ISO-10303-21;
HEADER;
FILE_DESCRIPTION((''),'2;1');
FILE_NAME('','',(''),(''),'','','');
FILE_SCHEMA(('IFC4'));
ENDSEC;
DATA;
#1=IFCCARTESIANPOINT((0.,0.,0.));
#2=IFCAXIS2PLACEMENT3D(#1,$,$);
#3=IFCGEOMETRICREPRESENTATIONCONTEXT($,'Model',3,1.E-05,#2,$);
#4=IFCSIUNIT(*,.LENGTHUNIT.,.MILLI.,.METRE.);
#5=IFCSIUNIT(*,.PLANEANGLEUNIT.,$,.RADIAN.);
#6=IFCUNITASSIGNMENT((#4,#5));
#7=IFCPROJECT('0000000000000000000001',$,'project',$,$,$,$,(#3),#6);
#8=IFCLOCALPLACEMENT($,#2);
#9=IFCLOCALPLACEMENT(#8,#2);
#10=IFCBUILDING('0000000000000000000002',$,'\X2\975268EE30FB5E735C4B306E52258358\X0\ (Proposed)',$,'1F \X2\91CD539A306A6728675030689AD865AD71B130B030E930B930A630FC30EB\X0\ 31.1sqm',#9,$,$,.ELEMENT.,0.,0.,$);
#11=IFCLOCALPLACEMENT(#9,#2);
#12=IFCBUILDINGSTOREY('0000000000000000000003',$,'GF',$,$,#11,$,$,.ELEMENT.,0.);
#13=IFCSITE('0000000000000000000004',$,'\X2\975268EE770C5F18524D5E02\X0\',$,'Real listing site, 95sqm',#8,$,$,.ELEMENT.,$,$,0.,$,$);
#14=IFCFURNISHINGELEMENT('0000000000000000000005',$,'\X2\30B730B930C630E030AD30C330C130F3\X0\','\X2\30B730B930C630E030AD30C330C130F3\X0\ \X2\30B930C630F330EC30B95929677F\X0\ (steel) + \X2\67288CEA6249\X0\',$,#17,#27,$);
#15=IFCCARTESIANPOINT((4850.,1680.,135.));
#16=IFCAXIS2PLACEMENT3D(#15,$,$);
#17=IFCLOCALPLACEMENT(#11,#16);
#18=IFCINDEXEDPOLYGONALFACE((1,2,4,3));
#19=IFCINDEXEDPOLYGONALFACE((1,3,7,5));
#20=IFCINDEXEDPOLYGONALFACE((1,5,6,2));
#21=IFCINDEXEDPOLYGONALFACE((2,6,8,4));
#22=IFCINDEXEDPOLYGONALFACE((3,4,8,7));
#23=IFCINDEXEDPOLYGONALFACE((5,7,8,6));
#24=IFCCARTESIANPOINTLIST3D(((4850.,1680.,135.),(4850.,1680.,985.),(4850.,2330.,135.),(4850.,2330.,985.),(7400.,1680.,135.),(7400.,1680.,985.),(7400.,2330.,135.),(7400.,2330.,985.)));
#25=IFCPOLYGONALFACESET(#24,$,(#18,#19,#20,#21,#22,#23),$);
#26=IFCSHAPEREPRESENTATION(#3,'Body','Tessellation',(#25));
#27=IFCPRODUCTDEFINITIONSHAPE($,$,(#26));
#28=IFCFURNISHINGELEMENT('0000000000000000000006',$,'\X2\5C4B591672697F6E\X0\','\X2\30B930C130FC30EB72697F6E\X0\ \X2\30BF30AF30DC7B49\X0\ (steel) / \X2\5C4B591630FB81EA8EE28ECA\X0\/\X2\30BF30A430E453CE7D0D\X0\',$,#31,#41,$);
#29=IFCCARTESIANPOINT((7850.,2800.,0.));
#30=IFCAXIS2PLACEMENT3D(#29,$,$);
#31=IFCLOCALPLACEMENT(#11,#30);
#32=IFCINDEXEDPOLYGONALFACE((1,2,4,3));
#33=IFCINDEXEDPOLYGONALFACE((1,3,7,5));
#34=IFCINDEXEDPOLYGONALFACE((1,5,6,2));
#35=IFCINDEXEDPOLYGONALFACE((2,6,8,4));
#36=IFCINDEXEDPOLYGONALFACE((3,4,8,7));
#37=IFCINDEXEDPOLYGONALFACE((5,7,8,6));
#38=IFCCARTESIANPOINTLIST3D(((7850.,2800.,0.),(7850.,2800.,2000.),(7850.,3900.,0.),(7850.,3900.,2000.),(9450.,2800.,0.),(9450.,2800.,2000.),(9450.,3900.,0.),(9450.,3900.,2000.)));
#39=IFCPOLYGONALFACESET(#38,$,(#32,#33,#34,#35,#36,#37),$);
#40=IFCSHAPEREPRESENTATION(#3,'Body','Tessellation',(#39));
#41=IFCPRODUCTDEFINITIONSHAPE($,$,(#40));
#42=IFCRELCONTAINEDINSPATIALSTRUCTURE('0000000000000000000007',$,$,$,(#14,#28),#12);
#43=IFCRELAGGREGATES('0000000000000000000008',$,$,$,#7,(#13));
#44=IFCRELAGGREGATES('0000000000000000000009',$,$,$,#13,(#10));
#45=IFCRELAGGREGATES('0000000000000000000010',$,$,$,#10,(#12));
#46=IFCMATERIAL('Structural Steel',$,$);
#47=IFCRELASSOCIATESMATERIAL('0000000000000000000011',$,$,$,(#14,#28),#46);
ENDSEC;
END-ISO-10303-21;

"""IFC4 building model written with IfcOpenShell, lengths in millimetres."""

from ifc_helpers import new_model, si_unit, frame, frame_2d, origin, place, context, project, spatial, rectangle, extrude, material, element, save


model = new_model("IFC4")

# Units and contexts
model_context = context("Model", 3, precision=1e-05, world=origin())
ifc_project = project(units=[si_unit("LENGTHUNIT", "METRE", prefix="MILLI"), si_unit("PLANEANGLEUNIT", "RADIAN")], contexts=[model_context])

# Site, building, storey
site_placement = place(None, origin())
site = spatial("IfcSite", under=ifc_project, at=site_placement, Name="青森県弘前市", ObjectType="Real listing site, 95sqm", CompositionType="ELEMENT", RefElevation=0.0)
building_placement = place(site_placement, origin())
building = spatial("IfcBuilding", under=site, at=building_placement, Name="青森・平屋の別荘 (Proposed)", ObjectType="1F 重厚な木材と高断熱グラスウール 31.1sqm", CompositionType="ELEMENT", ElevationOfRefHeight=0.0, ElevationOfTerrain=0.0)
storey_placement = place(building_placement, origin())
storey = spatial("IfcBuildingStorey", under=building, at=storey_placement, Name="GF", CompositionType="ELEMENT", Elevation=0.0)

# Shared definitions
ifc_material_1 = material(Name="Structural Steel")

# Furnishing elements
furnishing_1_placement = place(storey_placement, frame((4850.0, 1680.0, 135.0)))
element("IfcFurnishingElement", 1, at=furnishing_1_placement, inside=storey, material=ifc_material_1, Name="システムキッチン", Description="システムキッチン ステンレス天板 (steel) + 木質扉", context=model_context, shape_type="SweptSolid", body=[
    extrude(rectangle(XDim=2550.0, YDim=650.0, at=frame_2d((1275.0, 325.0))), frame((4850.0, 1680.0, 135.0)), (0.0, 0.0, 1.0), 850.0),
])
furnishing_2_placement = place(storey_placement, frame((7850.0, 2800.0, 0.0)))
element("IfcFurnishingElement", 2, at=furnishing_2_placement, inside=storey, material=ifc_material_1, Name="屋外物置", Description="スチール物置 タクボ等 (steel) / 屋外・自転車/タイヤ収納", context=model_context, shape_type="SweptSolid", body=[
    extrude(rectangle(XDim=1600.0, YDim=1100.0, at=frame_2d((800.0, 550.0))), frame((7850.0, 2800.0, 0.0)), (0.0, 0.0, 1.0), 2000.0),
])

save(model, "model.ifc")
